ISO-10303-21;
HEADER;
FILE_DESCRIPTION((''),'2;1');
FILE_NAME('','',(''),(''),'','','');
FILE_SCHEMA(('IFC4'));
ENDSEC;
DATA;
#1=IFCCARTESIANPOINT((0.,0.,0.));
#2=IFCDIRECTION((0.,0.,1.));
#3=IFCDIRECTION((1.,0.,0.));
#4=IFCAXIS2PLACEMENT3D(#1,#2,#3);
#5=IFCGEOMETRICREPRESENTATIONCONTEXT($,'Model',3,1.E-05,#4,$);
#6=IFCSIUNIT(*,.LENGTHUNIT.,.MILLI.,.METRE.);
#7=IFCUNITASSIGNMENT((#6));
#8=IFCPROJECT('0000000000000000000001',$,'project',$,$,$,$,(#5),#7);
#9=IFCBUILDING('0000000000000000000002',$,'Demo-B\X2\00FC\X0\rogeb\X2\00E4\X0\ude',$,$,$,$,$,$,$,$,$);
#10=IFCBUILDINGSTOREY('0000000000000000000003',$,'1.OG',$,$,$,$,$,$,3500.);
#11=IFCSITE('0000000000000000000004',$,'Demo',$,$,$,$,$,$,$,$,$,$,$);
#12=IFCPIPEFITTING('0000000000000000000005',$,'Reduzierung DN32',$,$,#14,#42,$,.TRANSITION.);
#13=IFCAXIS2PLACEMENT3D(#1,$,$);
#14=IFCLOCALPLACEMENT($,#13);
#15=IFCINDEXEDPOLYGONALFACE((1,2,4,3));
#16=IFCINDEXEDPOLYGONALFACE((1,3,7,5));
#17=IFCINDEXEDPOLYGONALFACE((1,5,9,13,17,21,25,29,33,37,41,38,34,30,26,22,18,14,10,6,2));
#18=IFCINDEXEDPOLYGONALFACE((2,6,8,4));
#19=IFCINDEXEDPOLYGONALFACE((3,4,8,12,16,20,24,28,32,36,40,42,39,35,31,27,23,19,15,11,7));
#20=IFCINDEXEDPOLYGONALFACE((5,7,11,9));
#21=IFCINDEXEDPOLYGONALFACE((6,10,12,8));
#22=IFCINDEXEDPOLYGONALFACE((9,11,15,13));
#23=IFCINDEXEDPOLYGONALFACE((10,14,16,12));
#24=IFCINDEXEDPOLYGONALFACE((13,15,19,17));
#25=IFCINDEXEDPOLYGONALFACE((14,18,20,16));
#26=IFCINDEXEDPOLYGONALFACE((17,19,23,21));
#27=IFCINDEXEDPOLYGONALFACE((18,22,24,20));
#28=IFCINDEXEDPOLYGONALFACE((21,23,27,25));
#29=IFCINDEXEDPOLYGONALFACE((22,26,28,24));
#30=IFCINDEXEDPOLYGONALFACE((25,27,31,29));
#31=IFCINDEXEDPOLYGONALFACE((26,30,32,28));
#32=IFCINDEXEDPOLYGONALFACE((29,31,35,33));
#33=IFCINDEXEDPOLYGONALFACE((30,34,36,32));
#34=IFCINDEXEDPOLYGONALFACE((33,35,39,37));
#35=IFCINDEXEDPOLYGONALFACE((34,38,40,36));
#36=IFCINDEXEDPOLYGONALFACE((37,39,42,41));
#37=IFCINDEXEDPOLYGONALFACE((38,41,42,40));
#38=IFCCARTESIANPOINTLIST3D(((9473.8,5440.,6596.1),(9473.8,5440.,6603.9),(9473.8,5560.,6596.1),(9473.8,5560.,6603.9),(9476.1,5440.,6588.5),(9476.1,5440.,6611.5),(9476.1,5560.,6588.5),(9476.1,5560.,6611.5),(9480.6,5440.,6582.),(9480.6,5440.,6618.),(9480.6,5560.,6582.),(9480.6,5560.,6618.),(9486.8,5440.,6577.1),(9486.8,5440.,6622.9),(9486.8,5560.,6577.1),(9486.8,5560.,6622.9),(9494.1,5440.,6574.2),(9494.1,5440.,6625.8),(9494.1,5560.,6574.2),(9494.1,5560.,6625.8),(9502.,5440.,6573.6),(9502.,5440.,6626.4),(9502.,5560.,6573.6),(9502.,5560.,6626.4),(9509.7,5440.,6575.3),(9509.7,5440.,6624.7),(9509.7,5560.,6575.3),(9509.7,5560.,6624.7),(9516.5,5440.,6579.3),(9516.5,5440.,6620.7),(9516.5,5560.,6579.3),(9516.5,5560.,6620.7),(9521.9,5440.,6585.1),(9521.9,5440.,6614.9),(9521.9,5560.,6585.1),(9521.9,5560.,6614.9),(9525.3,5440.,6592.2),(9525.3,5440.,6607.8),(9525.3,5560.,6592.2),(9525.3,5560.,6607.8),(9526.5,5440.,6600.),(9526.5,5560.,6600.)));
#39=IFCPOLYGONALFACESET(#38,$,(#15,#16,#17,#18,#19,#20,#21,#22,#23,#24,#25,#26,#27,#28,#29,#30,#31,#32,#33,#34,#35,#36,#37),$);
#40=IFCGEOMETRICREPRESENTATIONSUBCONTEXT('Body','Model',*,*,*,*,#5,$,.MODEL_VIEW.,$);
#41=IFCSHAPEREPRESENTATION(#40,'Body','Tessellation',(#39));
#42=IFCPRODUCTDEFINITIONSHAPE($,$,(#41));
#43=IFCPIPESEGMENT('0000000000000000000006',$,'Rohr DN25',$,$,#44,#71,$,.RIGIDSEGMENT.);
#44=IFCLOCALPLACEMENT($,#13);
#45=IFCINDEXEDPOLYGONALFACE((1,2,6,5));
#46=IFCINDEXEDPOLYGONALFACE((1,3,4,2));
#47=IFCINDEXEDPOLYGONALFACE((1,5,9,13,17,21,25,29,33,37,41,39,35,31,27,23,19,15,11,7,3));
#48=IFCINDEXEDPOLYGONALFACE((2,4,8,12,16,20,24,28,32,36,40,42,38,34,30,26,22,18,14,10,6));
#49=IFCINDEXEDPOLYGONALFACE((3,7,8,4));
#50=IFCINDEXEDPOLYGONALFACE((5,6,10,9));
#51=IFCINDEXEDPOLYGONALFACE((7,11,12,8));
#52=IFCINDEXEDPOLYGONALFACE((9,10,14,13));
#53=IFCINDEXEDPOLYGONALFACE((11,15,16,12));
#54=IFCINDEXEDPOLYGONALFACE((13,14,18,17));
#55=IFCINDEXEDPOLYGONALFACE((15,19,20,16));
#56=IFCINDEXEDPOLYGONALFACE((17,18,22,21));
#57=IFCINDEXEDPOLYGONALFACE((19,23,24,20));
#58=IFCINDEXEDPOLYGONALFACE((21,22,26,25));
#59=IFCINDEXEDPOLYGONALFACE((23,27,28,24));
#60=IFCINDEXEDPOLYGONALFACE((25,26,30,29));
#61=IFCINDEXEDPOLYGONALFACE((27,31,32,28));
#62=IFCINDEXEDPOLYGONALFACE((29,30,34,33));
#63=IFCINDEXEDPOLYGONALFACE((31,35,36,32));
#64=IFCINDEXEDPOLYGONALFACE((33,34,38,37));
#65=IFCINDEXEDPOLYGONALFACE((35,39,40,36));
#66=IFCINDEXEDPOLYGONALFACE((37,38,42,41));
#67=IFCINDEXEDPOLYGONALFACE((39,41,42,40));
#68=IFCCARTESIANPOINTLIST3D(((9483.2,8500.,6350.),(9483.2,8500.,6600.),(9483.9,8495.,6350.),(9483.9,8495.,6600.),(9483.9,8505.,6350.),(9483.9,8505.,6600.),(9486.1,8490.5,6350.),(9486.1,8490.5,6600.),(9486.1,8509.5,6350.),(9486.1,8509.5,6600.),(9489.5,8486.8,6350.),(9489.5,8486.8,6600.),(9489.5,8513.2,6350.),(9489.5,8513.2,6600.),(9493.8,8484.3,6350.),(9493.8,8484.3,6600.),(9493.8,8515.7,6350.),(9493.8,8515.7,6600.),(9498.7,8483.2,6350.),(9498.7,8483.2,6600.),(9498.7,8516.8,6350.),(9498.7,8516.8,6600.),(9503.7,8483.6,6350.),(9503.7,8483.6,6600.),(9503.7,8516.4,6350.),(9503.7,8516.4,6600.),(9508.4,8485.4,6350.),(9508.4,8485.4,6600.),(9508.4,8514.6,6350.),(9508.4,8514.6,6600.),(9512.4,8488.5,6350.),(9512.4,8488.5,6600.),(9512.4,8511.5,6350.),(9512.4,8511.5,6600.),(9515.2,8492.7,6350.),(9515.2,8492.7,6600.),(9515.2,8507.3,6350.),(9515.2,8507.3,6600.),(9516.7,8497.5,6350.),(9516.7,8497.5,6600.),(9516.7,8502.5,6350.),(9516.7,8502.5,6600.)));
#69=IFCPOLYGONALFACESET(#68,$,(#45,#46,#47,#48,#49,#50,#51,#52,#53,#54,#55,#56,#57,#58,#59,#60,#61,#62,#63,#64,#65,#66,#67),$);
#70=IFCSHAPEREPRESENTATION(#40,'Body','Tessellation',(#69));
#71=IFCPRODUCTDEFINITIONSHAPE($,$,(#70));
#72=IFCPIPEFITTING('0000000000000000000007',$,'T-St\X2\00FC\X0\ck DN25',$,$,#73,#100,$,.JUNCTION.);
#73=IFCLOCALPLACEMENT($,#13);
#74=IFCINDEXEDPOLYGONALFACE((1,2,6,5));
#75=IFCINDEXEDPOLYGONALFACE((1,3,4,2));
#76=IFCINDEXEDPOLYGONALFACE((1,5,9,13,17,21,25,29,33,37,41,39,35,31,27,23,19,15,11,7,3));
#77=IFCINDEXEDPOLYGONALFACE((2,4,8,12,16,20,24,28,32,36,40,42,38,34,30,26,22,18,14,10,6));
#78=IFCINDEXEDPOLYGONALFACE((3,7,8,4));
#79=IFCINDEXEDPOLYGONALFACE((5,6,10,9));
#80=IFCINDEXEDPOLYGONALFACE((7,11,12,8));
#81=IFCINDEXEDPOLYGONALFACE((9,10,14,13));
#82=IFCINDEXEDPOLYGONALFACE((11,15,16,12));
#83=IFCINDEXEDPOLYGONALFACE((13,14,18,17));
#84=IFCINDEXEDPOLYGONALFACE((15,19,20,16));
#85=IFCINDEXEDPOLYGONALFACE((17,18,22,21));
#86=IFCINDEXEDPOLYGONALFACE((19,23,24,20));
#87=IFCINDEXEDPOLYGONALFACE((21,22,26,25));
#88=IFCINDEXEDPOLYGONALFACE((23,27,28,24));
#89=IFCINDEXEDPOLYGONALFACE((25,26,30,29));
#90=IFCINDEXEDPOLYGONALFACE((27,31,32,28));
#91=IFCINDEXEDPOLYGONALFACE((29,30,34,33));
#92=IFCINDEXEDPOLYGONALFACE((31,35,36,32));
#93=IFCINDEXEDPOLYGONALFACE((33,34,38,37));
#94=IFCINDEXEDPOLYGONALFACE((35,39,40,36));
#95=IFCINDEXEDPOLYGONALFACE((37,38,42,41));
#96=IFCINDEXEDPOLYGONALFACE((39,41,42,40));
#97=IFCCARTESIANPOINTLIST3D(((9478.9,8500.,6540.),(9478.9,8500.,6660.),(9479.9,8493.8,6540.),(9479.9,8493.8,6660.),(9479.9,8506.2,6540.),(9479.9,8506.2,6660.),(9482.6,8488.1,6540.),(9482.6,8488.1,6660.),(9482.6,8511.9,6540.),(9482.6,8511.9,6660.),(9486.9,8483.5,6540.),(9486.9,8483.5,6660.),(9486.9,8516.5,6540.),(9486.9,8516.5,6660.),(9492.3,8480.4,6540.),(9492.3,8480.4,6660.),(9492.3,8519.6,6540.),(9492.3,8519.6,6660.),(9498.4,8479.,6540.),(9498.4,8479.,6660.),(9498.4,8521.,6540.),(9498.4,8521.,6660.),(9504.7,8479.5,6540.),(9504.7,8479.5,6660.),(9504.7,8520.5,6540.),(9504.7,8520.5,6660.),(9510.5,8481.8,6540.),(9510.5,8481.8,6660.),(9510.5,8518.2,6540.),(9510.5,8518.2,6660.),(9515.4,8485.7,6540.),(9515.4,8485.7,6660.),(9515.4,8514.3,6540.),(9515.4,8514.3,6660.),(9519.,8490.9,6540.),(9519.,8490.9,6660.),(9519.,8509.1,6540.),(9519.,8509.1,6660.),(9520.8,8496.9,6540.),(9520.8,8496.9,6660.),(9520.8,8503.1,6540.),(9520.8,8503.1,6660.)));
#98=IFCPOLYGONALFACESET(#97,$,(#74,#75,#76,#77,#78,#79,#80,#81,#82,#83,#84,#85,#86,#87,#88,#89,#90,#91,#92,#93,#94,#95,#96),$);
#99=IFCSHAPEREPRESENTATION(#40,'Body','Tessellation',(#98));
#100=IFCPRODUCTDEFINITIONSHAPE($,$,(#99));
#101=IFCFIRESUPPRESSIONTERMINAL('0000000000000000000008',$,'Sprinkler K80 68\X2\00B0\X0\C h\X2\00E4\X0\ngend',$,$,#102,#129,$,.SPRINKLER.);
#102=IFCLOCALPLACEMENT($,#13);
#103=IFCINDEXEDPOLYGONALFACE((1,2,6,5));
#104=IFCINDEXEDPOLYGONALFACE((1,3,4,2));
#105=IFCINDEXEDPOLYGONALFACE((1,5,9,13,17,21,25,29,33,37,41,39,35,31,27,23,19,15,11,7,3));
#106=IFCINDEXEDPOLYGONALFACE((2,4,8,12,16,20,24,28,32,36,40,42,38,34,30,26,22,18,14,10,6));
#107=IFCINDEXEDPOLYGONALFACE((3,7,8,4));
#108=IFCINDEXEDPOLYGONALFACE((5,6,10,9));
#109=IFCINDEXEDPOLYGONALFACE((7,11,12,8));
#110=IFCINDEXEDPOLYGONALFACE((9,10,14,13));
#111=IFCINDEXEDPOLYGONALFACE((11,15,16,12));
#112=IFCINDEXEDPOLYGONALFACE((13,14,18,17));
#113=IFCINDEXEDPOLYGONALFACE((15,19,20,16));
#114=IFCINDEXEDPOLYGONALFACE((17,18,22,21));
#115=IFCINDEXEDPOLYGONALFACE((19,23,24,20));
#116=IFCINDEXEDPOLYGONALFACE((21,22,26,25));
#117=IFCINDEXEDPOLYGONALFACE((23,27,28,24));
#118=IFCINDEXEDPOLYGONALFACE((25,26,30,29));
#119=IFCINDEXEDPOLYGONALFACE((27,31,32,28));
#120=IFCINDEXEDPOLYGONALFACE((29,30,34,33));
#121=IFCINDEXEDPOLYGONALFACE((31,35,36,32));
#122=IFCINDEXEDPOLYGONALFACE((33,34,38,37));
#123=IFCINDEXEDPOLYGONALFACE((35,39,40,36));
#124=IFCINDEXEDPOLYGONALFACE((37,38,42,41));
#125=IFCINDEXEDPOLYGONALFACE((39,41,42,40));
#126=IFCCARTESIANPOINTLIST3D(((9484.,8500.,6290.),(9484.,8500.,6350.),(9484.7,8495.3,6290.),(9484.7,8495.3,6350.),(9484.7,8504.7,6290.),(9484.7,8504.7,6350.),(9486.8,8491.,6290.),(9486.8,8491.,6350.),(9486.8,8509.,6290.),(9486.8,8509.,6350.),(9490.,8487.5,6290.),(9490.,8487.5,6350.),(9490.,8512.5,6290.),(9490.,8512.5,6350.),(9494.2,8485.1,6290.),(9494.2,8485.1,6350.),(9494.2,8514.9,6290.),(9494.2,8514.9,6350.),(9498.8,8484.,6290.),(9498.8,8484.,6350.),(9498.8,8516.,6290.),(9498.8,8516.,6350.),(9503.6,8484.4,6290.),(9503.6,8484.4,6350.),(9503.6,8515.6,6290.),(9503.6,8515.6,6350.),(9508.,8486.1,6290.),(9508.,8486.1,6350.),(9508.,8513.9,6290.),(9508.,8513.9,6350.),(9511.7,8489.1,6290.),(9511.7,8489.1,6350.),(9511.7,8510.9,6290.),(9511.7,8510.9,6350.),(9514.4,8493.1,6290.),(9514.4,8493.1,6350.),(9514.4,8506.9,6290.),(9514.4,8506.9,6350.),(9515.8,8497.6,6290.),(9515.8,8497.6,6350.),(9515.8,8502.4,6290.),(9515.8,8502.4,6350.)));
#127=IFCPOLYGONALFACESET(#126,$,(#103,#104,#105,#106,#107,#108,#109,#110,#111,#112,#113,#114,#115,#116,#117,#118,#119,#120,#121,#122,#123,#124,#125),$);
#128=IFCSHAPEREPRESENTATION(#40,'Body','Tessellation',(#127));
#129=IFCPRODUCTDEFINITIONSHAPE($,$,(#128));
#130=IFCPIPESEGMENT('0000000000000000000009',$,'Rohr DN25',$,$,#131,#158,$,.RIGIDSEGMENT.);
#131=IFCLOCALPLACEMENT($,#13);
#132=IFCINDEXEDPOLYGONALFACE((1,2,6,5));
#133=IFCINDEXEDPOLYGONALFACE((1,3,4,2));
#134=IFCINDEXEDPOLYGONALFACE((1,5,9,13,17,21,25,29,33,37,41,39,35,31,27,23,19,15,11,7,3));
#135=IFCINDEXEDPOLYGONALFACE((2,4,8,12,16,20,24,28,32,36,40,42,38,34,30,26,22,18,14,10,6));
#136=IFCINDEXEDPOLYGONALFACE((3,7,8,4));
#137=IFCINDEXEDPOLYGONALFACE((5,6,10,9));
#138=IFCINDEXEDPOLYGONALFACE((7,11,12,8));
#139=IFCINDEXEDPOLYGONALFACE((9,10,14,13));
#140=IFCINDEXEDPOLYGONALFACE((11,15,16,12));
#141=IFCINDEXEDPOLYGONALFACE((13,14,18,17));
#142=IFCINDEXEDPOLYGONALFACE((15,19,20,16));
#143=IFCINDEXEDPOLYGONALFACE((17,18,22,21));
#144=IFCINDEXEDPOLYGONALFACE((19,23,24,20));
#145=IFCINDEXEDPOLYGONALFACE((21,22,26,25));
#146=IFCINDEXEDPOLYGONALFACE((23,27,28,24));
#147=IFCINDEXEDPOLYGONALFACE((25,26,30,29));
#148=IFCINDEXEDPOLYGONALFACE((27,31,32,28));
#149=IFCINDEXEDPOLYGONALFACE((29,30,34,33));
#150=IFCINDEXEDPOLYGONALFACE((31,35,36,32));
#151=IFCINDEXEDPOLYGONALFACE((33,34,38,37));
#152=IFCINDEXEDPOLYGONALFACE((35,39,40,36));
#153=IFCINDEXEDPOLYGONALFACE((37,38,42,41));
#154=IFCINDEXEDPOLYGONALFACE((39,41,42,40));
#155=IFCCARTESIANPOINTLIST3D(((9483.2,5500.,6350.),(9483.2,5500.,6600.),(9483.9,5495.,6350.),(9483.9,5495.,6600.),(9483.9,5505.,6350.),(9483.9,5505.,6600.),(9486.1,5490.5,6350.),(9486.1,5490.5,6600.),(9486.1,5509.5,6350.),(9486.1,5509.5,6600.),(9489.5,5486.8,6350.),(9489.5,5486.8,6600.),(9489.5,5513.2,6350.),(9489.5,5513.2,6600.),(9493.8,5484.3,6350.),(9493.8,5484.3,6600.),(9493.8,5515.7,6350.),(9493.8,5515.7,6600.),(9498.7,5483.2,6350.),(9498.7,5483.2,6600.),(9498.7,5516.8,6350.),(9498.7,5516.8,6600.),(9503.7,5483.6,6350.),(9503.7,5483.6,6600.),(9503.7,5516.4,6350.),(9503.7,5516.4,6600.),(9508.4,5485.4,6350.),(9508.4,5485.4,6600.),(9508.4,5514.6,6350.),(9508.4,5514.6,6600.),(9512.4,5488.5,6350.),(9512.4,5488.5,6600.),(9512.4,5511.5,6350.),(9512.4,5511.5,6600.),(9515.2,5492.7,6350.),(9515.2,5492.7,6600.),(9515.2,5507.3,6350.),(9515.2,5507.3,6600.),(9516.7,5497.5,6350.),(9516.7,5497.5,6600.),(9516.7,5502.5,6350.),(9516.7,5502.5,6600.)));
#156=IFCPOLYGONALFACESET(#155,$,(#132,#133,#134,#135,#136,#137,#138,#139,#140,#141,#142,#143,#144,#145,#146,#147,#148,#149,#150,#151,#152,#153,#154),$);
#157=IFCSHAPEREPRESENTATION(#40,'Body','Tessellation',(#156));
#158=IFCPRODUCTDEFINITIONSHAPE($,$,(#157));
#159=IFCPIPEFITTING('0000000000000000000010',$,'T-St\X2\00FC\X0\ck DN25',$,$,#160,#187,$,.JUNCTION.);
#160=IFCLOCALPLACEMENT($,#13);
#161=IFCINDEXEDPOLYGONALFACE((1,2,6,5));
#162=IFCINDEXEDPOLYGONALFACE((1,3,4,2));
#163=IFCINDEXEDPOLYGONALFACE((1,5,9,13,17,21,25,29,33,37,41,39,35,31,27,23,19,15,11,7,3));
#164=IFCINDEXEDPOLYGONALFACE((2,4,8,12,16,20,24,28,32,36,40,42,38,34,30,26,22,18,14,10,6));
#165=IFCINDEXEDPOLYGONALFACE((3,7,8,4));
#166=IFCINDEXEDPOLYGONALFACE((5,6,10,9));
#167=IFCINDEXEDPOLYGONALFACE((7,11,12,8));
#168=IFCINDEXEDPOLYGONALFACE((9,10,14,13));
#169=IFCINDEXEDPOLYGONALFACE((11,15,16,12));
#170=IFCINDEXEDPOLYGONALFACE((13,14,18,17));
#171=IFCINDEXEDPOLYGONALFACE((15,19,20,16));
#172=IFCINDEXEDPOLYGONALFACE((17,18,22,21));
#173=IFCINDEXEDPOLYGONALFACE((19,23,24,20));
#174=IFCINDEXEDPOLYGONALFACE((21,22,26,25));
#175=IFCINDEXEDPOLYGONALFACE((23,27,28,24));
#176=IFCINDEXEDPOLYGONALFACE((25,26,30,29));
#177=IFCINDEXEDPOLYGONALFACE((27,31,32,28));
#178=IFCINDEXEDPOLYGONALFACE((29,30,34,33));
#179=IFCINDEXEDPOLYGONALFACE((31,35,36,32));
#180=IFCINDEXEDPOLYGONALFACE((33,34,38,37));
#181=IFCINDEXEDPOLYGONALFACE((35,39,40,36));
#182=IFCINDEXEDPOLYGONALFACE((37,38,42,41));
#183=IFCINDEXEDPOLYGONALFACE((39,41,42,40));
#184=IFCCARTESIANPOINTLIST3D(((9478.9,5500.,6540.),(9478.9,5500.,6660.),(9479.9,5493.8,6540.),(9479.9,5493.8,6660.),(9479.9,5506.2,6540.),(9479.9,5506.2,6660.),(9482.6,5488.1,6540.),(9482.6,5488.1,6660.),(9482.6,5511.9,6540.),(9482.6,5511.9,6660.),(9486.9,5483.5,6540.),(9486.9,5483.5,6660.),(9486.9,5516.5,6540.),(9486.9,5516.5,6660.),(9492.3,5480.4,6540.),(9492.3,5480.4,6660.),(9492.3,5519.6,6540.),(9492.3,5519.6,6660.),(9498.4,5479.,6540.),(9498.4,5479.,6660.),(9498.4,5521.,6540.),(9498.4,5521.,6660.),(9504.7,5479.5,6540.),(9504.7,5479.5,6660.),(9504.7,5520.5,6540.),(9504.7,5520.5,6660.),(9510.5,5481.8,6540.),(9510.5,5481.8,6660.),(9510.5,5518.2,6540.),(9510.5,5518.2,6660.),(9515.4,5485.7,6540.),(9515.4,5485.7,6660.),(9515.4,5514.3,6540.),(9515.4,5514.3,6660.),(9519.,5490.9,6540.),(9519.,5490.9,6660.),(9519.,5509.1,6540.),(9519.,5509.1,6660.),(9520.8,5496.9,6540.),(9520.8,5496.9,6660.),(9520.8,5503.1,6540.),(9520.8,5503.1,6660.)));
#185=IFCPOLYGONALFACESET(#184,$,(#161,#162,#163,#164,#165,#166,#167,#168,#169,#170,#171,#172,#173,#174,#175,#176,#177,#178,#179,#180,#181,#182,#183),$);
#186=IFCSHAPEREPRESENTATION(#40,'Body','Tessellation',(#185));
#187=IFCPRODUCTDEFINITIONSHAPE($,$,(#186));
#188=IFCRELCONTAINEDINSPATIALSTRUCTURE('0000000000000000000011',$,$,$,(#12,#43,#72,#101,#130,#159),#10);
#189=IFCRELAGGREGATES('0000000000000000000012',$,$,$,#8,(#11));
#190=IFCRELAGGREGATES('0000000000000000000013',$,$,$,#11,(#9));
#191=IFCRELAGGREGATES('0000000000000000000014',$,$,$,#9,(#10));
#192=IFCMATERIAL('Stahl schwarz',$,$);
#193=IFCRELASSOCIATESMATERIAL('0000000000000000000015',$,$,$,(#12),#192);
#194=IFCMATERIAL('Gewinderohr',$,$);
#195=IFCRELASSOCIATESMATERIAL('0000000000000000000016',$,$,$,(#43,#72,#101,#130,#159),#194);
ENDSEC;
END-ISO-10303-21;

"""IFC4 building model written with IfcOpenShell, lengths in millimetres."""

from ifc_helpers import new_model, si_unit, frame, origin_with_axes, place, context, subcontext, project, spatial, circle, extrude, material, element, save


model = new_model("IFC4")

# Units and contexts
model_context = context("Model", 3, precision=1e-05, world=origin_with_axes())
body_context = subcontext(model_context, "Body", "Model", "MODEL_VIEW")
ifc_project = project(units=[si_unit("LENGTHUNIT", "METRE", prefix="MILLI")], contexts=[model_context])

# Site, building, storey
site = spatial("IfcSite", under=ifc_project, Name="Demo")
building = spatial("IfcBuilding", under=site, Name="Demo-Bürogebäude")
storey = spatial("IfcBuildingStorey", under=building, Name="1.OG", Elevation=3500.0)

# Shared definitions
ifc_material_1 = material(Name="Stahl schwarz")

# Shared definitions
ifc_material_2 = material(Name="Gewinderohr")

# Pipe fitting
pipe_fitting_1_placement = place(None, frame((9500.0, 5560.0, 6600.0), z_axis=(0.0, -1.0, 0.0), x_axis=(1.0, 0.0, 0.0)))
element("IfcPipeFitting", 1, at=pipe_fitting_1_placement, inside=storey, material=ifc_material_1, Name="Reduzierung DN32", PredefinedType="TRANSITION", context=body_context, shape_type="SweptSolid", body=[
    extrude(circle(Radius=26.5), origin_with_axes(), (0.0, 0.0, 1.0), 120.0),
])

# Pipe segment
pipe_segment_1_placement = place(None, frame((9500.0, 8500.0, 6600.0), z_axis=(0.0, 0.0, -1.0), x_axis=(-1.0, 0.0, 0.0)))
element("IfcPipeSegment", 2, at=pipe_segment_1_placement, inside=storey, material=ifc_material_2, Name="Rohr DN25", PredefinedType="RIGIDSEGMENT", context=body_context, shape_type="SweptSolid", body=[
    extrude(circle(Radius=16.9), origin_with_axes(), (0.0, 0.0, 1.0), 250.0),
])

# Pipe fitting
pipe_fitting_2_placement = place(None, frame((9500.0, 8500.0, 6660.0), z_axis=(0.0, 0.0, -1.0), x_axis=(-1.0, 0.0, 0.0)))
element("IfcPipeFitting", 3, at=pipe_fitting_2_placement, inside=storey, material=ifc_material_2, Name="T-Stück DN25", PredefinedType="JUNCTION", context=body_context, shape_type="SweptSolid", body=[
    extrude(circle(Radius=21.1), origin_with_axes(), (0.0, 0.0, 1.0), 120.0),
])

# Fire suppression terminal
fire_suppression_terminal_1_placement = place(None, frame((9500.0, 8500.0, 6350.0), z_axis=(0.0, 0.0, -1.0), x_axis=(-1.0, 0.0, 0.0)))
element("IfcFireSuppressionTerminal", 4, at=fire_suppression_terminal_1_placement, inside=storey, material=ifc_material_2, Name="Sprinkler K80 68°C hängend", PredefinedType="SPRINKLER", context=body_context, shape_type="SweptSolid", body=[
    extrude(circle(Radius=16.0), origin_with_axes(), (0.0, 0.0, 1.0), 60.0),
])

# Pipe segment
pipe_segment_2_placement = place(None, frame((9500.0, 5500.0, 6600.0), z_axis=(0.0, 0.0, -1.0), x_axis=(-1.0, 0.0, 0.0)))
element("IfcPipeSegment", 5, at=pipe_segment_2_placement, inside=storey, material=ifc_material_2, Name="Rohr DN25", PredefinedType="RIGIDSEGMENT", context=body_context, shape_type="SweptSolid", body=[
    extrude(circle(Radius=16.9), origin_with_axes(), (0.0, 0.0, 1.0), 250.0),
])

# Pipe fitting
pipe_fitting_3_placement = place(None, frame((9500.0, 5500.0, 6660.0), z_axis=(0.0, 0.0, -1.0), x_axis=(-1.0, 0.0, 0.0)))
element("IfcPipeFitting", 6, at=pipe_fitting_3_placement, inside=storey, material=ifc_material_2, Name="T-Stück DN25", PredefinedType="JUNCTION", context=body_context, shape_type="SweptSolid", body=[
    extrude(circle(Radius=21.1), origin_with_axes(), (0.0, 0.0, 1.0), 120.0),
])

save(model, "model.ifc")
